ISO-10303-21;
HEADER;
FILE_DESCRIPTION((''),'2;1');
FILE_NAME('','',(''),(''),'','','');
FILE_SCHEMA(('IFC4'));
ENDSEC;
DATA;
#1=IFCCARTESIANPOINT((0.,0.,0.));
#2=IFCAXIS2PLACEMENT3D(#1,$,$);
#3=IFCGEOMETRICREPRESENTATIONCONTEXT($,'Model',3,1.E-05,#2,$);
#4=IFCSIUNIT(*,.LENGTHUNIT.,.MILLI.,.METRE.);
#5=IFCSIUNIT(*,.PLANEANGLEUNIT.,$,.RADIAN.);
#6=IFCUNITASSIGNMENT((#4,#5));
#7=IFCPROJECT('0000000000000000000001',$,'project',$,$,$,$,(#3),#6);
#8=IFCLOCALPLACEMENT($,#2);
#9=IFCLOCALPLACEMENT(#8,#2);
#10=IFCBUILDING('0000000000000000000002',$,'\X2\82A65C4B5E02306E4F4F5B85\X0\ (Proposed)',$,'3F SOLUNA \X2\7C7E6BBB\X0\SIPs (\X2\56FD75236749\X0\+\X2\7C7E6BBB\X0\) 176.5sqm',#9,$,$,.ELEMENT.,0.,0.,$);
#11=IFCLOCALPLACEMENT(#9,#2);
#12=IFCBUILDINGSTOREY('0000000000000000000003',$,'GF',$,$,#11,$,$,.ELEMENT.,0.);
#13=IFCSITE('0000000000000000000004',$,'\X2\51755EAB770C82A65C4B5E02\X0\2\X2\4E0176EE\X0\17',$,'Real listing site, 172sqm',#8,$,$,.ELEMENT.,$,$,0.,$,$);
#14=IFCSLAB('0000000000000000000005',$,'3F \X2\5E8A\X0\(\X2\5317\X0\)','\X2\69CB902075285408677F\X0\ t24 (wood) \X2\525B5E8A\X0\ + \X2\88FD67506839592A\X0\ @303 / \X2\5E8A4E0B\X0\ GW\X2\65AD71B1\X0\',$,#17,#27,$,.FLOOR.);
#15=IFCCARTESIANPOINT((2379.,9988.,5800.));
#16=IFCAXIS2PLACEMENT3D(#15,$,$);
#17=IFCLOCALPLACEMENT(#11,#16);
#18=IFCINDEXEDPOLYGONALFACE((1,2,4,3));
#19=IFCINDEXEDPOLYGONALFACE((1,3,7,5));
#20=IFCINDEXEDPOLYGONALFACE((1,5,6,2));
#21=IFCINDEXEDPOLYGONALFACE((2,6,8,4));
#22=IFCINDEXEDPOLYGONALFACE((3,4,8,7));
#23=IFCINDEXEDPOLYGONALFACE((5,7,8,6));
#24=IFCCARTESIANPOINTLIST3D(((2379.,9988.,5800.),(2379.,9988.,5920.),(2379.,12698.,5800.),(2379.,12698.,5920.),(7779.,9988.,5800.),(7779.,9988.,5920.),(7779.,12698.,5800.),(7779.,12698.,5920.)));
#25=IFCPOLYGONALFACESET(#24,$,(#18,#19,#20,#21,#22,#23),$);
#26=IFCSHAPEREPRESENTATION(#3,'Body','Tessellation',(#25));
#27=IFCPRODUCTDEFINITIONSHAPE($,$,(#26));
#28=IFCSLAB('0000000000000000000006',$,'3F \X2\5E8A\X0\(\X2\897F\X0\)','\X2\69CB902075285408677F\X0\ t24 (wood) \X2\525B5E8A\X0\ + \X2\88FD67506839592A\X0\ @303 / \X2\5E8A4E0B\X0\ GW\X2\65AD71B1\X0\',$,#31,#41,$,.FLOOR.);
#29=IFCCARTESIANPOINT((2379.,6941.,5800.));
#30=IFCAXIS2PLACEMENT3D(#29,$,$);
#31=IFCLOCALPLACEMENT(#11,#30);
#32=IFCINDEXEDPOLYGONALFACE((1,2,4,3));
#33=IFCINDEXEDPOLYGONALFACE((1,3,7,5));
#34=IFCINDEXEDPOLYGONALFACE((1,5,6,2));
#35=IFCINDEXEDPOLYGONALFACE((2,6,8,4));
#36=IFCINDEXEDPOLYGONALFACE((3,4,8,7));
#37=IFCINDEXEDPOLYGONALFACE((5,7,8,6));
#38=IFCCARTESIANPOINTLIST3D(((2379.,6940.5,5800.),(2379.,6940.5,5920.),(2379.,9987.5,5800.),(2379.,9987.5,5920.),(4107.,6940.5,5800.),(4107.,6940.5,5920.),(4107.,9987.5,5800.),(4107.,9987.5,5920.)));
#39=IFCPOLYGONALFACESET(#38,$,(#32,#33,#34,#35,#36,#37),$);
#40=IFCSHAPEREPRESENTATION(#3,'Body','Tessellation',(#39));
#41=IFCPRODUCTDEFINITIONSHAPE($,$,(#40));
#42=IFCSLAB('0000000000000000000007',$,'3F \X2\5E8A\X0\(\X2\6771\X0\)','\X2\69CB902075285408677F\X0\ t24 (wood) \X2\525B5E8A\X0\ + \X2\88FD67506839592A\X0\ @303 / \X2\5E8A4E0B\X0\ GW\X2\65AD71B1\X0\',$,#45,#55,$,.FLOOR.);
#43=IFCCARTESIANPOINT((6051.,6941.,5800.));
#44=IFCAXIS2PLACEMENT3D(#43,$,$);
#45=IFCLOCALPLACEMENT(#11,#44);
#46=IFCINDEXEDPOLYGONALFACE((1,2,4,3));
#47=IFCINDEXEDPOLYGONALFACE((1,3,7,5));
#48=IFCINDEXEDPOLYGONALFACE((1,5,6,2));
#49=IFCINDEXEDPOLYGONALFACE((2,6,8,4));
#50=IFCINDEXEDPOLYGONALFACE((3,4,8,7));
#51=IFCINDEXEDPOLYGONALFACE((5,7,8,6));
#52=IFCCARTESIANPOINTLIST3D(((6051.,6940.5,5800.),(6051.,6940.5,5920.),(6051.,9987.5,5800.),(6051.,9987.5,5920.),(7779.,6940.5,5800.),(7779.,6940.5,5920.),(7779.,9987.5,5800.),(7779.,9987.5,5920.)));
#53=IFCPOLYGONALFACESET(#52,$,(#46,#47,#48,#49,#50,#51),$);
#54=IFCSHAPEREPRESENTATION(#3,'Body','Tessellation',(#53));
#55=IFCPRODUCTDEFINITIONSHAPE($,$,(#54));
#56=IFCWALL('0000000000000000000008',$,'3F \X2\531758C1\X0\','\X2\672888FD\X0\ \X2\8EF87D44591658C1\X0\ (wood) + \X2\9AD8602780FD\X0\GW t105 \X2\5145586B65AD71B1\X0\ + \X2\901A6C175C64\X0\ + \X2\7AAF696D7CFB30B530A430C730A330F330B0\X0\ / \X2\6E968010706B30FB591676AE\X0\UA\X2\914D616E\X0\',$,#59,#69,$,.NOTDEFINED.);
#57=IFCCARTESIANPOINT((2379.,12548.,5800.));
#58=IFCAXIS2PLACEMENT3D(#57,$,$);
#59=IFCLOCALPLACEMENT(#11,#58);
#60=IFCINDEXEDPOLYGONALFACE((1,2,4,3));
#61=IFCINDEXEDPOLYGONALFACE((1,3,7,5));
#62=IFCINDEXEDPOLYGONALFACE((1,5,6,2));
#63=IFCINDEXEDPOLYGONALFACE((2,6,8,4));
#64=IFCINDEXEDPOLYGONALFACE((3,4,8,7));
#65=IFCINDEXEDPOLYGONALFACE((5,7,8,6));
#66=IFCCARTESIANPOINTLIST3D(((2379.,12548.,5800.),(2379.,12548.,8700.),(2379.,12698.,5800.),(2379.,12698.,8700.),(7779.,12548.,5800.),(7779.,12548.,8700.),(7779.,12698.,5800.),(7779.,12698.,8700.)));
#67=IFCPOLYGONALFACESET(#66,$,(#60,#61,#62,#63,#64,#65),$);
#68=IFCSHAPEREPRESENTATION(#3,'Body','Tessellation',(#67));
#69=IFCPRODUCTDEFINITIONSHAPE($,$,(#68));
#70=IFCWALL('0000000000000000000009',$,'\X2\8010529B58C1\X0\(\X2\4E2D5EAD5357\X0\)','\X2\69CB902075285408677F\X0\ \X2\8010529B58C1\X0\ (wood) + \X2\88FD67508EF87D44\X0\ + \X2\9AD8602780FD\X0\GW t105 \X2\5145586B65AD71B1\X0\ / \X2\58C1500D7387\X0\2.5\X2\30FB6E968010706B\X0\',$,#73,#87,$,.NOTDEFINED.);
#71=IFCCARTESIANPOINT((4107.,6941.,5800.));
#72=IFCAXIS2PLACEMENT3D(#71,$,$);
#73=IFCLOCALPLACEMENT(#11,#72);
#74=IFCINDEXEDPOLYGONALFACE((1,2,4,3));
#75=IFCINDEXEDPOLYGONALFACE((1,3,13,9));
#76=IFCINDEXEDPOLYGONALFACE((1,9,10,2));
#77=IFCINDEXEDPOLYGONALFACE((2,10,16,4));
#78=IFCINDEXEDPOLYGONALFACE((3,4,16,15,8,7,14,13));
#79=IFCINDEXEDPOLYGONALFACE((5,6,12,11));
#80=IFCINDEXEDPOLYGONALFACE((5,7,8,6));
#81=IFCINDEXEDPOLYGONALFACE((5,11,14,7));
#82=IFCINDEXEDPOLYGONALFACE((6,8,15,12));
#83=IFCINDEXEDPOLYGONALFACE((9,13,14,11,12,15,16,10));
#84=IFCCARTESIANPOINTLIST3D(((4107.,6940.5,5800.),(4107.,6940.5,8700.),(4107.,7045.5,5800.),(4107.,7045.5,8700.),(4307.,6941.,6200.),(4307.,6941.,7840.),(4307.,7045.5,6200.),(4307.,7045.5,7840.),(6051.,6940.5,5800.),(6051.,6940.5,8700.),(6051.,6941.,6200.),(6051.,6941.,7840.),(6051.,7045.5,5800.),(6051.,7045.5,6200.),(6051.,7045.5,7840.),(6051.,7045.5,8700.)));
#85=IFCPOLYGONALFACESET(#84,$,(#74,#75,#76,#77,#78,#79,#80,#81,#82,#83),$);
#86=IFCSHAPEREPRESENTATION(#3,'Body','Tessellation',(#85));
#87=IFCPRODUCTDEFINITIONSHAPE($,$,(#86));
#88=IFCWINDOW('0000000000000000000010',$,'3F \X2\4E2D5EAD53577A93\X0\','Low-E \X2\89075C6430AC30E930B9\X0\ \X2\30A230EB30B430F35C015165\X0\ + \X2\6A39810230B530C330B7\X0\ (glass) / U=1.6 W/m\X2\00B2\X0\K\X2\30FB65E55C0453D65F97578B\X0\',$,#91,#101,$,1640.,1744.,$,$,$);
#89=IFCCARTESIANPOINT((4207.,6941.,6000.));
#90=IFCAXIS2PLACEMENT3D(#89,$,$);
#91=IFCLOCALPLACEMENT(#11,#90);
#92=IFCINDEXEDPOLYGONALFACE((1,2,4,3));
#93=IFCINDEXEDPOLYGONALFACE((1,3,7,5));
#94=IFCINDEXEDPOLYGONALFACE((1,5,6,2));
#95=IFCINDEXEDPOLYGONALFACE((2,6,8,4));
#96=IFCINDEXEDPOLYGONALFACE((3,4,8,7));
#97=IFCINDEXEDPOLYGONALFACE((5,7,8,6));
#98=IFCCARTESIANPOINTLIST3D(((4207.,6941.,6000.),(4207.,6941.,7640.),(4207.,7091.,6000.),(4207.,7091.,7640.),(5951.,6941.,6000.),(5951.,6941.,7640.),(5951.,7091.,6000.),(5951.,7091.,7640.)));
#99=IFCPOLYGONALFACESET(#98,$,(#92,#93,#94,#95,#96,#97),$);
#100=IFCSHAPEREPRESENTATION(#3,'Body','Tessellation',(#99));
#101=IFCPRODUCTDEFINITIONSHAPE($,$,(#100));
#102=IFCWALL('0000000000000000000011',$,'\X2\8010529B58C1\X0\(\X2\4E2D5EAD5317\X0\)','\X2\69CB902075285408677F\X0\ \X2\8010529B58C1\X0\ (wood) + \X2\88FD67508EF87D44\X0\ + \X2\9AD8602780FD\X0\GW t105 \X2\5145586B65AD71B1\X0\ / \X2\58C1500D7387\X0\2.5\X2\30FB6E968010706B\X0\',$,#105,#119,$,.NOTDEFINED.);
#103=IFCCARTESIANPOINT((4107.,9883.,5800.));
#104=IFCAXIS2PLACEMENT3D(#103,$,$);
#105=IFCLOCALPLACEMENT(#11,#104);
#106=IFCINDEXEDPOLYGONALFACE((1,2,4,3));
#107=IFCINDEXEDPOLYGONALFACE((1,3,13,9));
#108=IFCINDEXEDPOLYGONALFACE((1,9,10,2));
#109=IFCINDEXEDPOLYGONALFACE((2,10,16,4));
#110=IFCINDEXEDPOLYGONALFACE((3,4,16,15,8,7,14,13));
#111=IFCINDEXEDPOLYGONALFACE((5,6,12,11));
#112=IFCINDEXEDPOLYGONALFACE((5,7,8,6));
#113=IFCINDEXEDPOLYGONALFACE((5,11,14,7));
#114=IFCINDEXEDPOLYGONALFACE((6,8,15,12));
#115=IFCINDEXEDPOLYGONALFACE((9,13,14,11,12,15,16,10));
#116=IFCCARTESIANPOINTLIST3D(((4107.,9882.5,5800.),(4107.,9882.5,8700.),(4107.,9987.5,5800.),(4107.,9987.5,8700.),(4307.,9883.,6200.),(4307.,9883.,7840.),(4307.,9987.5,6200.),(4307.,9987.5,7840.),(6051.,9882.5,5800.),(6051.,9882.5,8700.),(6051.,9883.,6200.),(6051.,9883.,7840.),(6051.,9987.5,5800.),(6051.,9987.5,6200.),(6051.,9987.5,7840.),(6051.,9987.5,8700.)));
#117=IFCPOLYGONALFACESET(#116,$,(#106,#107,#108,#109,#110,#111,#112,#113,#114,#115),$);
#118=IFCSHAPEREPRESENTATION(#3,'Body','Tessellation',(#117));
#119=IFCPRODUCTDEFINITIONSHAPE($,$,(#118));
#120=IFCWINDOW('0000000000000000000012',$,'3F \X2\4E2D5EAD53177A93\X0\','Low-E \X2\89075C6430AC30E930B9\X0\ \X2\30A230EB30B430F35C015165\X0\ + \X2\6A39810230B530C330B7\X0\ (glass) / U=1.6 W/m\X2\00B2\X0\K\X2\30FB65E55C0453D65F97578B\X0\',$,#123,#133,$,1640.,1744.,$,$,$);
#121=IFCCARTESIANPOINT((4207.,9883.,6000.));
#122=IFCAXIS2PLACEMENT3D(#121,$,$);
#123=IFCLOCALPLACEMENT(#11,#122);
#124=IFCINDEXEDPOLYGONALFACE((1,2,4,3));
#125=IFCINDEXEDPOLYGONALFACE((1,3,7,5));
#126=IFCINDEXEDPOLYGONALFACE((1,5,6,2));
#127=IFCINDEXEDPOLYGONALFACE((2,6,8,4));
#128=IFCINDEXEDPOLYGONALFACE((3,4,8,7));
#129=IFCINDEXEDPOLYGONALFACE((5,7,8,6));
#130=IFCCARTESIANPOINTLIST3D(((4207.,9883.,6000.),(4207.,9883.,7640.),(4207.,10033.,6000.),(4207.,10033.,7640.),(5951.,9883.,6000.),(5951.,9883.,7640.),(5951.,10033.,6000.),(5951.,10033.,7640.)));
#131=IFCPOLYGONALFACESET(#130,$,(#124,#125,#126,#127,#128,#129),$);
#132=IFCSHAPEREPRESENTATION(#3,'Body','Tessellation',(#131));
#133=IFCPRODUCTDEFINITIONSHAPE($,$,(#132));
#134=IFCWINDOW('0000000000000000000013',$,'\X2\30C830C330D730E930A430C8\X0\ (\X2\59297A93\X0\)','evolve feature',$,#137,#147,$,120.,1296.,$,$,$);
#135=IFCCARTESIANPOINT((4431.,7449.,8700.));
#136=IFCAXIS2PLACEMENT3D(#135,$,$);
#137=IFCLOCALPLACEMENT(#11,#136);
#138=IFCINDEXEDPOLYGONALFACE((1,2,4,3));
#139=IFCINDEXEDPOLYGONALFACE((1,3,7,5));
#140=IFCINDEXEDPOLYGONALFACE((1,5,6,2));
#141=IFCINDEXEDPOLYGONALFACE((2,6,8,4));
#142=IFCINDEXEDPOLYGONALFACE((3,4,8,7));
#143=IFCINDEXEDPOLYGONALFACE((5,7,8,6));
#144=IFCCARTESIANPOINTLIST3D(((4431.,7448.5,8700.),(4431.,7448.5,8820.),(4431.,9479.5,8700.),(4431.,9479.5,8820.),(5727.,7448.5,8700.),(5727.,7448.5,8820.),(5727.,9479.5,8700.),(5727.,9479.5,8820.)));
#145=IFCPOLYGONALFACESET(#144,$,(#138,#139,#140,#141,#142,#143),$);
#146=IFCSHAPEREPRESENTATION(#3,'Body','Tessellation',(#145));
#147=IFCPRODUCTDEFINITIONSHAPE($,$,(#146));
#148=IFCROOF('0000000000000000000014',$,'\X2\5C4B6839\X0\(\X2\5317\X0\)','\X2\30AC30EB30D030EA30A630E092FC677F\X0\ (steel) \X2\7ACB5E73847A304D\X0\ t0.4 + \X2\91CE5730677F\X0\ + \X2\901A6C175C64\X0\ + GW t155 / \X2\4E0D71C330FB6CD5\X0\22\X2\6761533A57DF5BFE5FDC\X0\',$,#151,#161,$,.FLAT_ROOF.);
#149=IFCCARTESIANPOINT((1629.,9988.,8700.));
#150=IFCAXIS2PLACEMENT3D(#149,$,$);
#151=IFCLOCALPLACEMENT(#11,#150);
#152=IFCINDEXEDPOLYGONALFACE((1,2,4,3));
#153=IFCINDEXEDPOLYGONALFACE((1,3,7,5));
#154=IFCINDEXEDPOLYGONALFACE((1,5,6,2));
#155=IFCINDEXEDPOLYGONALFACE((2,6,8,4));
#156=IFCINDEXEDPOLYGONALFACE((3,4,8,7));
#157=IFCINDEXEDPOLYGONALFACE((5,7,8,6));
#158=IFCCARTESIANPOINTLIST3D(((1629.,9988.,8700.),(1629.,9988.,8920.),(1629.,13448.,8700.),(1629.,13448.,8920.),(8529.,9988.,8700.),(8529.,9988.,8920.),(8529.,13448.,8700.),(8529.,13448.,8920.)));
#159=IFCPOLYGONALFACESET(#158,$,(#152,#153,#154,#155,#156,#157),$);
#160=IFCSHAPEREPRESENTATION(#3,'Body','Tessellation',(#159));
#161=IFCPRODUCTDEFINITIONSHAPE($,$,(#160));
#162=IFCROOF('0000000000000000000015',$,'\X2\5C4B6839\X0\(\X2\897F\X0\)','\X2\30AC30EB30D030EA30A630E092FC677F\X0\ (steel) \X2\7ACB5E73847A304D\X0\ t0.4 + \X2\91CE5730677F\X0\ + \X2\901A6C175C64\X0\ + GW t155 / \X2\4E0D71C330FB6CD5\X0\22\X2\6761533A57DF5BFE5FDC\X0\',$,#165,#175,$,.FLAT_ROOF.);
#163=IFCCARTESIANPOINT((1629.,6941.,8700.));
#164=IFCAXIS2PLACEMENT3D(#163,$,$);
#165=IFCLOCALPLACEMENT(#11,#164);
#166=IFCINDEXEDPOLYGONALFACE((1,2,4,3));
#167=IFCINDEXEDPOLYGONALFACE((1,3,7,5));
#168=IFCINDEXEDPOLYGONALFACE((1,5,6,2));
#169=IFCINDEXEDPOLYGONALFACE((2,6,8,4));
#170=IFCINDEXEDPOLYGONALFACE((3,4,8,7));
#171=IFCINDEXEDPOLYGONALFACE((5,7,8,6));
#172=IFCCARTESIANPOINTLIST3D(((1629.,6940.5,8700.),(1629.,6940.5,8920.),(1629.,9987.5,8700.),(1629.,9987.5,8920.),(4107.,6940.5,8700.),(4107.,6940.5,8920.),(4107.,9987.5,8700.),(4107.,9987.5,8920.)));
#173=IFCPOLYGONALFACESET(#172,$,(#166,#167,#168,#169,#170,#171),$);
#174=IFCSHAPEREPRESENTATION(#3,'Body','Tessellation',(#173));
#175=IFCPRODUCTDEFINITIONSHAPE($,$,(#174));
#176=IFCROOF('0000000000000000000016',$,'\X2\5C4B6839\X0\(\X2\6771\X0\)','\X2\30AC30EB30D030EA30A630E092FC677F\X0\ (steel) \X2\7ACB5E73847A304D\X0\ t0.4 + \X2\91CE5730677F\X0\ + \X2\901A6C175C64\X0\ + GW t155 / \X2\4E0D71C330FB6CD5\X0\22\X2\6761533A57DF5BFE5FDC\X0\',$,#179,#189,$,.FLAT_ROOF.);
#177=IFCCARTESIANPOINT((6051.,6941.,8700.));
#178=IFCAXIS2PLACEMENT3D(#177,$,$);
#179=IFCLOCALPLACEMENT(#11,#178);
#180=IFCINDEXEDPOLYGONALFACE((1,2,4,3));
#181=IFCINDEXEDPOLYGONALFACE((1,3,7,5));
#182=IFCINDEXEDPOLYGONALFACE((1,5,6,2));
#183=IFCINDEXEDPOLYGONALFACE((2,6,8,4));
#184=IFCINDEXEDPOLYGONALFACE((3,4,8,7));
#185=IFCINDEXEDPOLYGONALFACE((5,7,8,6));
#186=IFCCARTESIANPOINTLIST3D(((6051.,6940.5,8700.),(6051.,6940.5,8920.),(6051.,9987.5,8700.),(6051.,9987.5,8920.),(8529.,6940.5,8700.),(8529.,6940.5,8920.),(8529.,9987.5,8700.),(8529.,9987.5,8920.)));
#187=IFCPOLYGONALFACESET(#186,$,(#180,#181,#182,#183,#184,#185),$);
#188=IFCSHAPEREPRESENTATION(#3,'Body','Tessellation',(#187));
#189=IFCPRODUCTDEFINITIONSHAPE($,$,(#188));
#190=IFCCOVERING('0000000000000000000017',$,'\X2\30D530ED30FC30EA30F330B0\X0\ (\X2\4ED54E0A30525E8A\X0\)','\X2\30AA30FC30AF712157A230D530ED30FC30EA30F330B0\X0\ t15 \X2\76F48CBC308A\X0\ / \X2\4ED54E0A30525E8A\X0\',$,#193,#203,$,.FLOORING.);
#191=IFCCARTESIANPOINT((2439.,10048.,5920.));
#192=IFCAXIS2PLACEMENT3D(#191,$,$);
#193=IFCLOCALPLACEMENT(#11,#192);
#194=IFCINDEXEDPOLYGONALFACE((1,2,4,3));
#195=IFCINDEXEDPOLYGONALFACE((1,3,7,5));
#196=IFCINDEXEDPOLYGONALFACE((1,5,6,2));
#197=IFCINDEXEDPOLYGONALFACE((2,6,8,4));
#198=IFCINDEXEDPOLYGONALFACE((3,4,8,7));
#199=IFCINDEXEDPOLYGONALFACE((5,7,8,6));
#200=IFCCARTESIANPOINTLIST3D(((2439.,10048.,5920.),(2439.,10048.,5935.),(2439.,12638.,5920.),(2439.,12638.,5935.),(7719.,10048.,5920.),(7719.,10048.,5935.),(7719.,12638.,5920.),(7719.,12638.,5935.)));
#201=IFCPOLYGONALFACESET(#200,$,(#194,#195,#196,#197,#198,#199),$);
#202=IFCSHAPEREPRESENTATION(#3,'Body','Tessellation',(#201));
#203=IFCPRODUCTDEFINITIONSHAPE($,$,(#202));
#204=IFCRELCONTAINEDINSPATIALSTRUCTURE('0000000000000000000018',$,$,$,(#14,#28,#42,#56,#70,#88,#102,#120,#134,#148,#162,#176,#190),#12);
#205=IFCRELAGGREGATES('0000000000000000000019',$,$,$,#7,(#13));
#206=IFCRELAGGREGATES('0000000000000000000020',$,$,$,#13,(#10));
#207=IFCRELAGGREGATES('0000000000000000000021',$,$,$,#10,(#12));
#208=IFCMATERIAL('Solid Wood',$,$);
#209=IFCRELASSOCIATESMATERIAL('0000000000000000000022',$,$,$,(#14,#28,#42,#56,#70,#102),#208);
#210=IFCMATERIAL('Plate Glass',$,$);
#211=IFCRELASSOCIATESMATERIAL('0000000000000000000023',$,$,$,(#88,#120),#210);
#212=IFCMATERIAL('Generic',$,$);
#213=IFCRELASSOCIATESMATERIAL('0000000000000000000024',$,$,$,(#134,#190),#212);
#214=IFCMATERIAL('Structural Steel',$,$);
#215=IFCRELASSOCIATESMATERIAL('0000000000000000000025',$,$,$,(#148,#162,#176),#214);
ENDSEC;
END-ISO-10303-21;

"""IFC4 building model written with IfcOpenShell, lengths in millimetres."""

from ifc_helpers import new_model, si_unit, frame, frame_2d, origin, place, context, project, spatial, rectangle, extrude, material, element, fill, save


model = new_model("IFC4")

# Units and contexts
model_context = context("Model", 3, precision=1e-05, world=origin())
ifc_project = project(units=[si_unit("LENGTHUNIT", "METRE", prefix="MILLI"), si_unit("PLANEANGLEUNIT", "RADIAN")], contexts=[model_context])

# Site, building, storey
site_placement = place(None, origin())
site = spatial("IfcSite", under=ifc_project, at=site_placement, Name="兵庫県芦屋市2丁目17", ObjectType="Real listing site, 172sqm", CompositionType="ELEMENT", RefElevation=0.0)
building_placement = place(site_placement, origin())
building = spatial("IfcBuilding", under=site, at=building_placement, Name="芦屋市の住宅 (Proposed)", ObjectType="3F SOLUNA 籾殻SIPs (国産杉+籾殻) 176.5sqm", CompositionType="ELEMENT", ElevationOfRefHeight=0.0, ElevationOfTerrain=0.0)
storey_placement = place(building_placement, origin())
storey = spatial("IfcBuildingStorey", under=building, at=storey_placement, Name="GF", CompositionType="ELEMENT", Elevation=0.0)

# Slabs
ifc_material_1 = material(Name="Solid Wood")
slab_1_placement = place(storey_placement, frame((2379.0, 9988.0, 5800.0)))
element("IfcSlab", 1, at=slab_1_placement, inside=storey, material=ifc_material_1, Name="3F 床(北)", Description="構造用合板 t24 (wood) 剛床 + 製材根太 @303 / 床下 GW断熱", PredefinedType="FLOOR", context=model_context, shape_type="SweptSolid", body=[
    extrude(rectangle(XDim=5400.0, YDim=2710.0, at=frame_2d((2700.0, 1355.0))), frame((2379.0, 9988.0, 5800.0)), (0.0, 0.0, 1.0), 120.0),
])
slab_2_placement = place(storey_placement, frame((2379.0, 6941.0, 5800.0)))
element("IfcSlab", 2, at=slab_2_placement, inside=storey, material=ifc_material_1, Name="3F 床(西)", Description="構造用合板 t24 (wood) 剛床 + 製材根太 @303 / 床下 GW断熱", PredefinedType="FLOOR", context=model_context, shape_type="SweptSolid", body=[
    extrude(rectangle(XDim=1728.0, YDim=3047.0, at=frame_2d((864.0, 1523.0))), frame((2379.0, 6941.0, 5800.0)), (0.0, 0.0, 1.0), 120.0),
])
slab_3_placement = place(storey_placement, frame((6051.0, 6941.0, 5800.0)))
element("IfcSlab", 3, at=slab_3_placement, inside=storey, material=ifc_material_1, Name="3F 床(東)", Description="構造用合板 t24 (wood) 剛床 + 製材根太 @303 / 床下 GW断熱", PredefinedType="FLOOR", context=model_context, shape_type="SweptSolid", body=[
    extrude(rectangle(XDim=1728.0, YDim=3047.0, at=frame_2d((864.0, 1523.0))), frame((6051.0, 6941.0, 5800.0)), (0.0, 0.0, 1.0), 120.0),
])

# Wall
wall_1_placement = place(storey_placement, frame((2379.0, 12548.0, 5800.0)))
element("IfcWall", 4, at=wall_1_placement, inside=storey, material=ifc_material_1, Name="3F 北壁", Description="木製 軸組外壁 (wood) + 高性能GW t105 充填断熱 + 通気層 + 窯業系サイディング / 準耐火・外皮UA配慮", PredefinedType="NOTDEFINED", context=model_context, shape_type="SweptSolid", body=[
    extrude(rectangle(XDim=5400.0, YDim=150.0, at=frame_2d((2700.0, 75.0))), frame((2379.0, 12548.0, 5800.0)), (0.0, 0.0, 1.0), 2900.0),
])

# Walls, openings, windows
wall_2_placement = place(storey_placement, frame((4107.0, 6941.0, 5800.0)))
wall_2 = element("IfcWall", 5, at=wall_2_placement, inside=storey, material=ifc_material_1, Name="耐力壁(中庭南)", Description="構造用合板 耐力壁 (wood) + 製材軸組 + 高性能GW t105 充填断熱 / 壁倍率2.5・準耐火", PredefinedType="NOTDEFINED", context=model_context, shape_type="SweptSolid", body=[
    extrude(rectangle(XDim=1944.0, YDim=105.0, at=frame_2d((972.0, 52.0))), frame((4107.0, 6941.0, 5800.0)), (0.0, 0.0, 1.0), 2900.0),
])
opening_1_placement = place(storey_placement, frame((4207.0, 6941.0, 6000.0)))
opening_1 = element("IfcOpeningElement", 6, at=opening_1_placement, cuts=wall_2, PredefinedType="NOTDEFINED", context=model_context, shape_type="SweptSolid", body=[
    extrude(rectangle(XDim=1744.0, YDim=150.0, at=frame_2d((872.0, 75.0))), frame((4207.0, 6941.0, 6000.0)), (0.0, 0.0, 1.0), 1640.0),
])
ifc_material_2 = material(Name="Plate Glass")
window_1_placement = place(storey_placement, frame((4207.0, 6941.0, 6000.0)))
window_1 = element("IfcWindow", 7, at=window_1_placement, inside=storey, material=ifc_material_2, Name="3F 中庭南窓", Description="Low-E 複層ガラス アルゴン封入 + 樹脂サッシ (glass) / U=1.6 W/m²K・日射取得型", OverallHeight=1640.0, OverallWidth=1744.0, context=model_context, shape_type="SweptSolid", body=[
    extrude(rectangle(XDim=1744.0, YDim=150.0, at=frame_2d((872.0, 75.0))), frame((4207.0, 6941.0, 6000.0)), (0.0, 0.0, 1.0), 1640.0),
])
fill(opening_1, window_1)
wall_3_placement = place(storey_placement, frame((4107.0, 9883.0, 5800.0)))
wall_3 = element("IfcWall", 8, at=wall_3_placement, inside=storey, material=ifc_material_1, Name="耐力壁(中庭北)", Description="構造用合板 耐力壁 (wood) + 製材軸組 + 高性能GW t105 充填断熱 / 壁倍率2.5・準耐火", PredefinedType="NOTDEFINED", context=model_context, shape_type="SweptSolid", body=[
    extrude(rectangle(XDim=1944.0, YDim=105.0, at=frame_2d((972.0, 52.0))), frame((4107.0, 9883.0, 5800.0)), (0.0, 0.0, 1.0), 2900.0),
])
opening_2_placement = place(storey_placement, frame((4207.0, 9883.0, 6000.0)))
opening_2 = element("IfcOpeningElement", 9, at=opening_2_placement, cuts=wall_3, PredefinedType="NOTDEFINED", context=model_context, shape_type="SweptSolid", body=[
    extrude(rectangle(XDim=1744.0, YDim=150.0, at=frame_2d((872.0, 75.0))), frame((4207.0, 9883.0, 6000.0)), (0.0, 0.0, 1.0), 1640.0),
])
window_2_placement = place(storey_placement, frame((4207.0, 9883.0, 6000.0)))
window_2 = element("IfcWindow", 10, at=window_2_placement, inside=storey, material=ifc_material_2, Name="3F 中庭北窓", Description="Low-E 複層ガラス アルゴン封入 + 樹脂サッシ (glass) / U=1.6 W/m²K・日射取得型", OverallHeight=1640.0, OverallWidth=1744.0, context=model_context, shape_type="SweptSolid", body=[
    extrude(rectangle(XDim=1744.0, YDim=150.0, at=frame_2d((872.0, 75.0))), frame((4207.0, 9883.0, 6000.0)), (0.0, 0.0, 1.0), 1640.0),
])
fill(opening_2, window_2)

# Window
ifc_material_3 = material(Name="Generic")
window_3_placement = place(storey_placement, frame((4431.0, 7449.0, 8700.0)))
element("IfcWindow", 11, at=window_3_placement, inside=storey, material=ifc_material_3, Name="トップライト (天窓)", Description="evolve feature", OverallHeight=120.0, OverallWidth=1296.0, context=model_context, shape_type="SweptSolid", body=[
    extrude(rectangle(XDim=1296.0, YDim=2031.0, at=frame_2d((648.0, 1015.0))), frame((4431.0, 7449.0, 8700.0)), (0.0, 0.0, 1.0), 120.0),
])

# Roofs
ifc_material_4 = material(Name="Structural Steel")
for number, where, name in (
    (12, (1629.0, 9988.0, 8700.0), "屋根(北)"),
):
    element("IfcRoof", number, at=place(storey_placement, frame(where)), inside=storey, material=ifc_material_4, Name=name, Description="ガルバリウム鋼板 (steel) 立平葺き t0.4 + 野地板 + 通気層 + GW t155 / 不燃・法22条区域対応", PredefinedType="FLAT_ROOF", context=model_context, shape_type="SweptSolid", body=[
        extrude(rectangle(XDim=6900.0, YDim=3460.0, at=frame_2d((3450.0, 1730.0))), frame((1629.0, 9988.0, 8700.0)), (0.0, 0.0, 1.0), 220.0),
    ])
roof_1_placement = place(storey_placement, frame((1629.0, 6941.0, 8700.0)))
element("IfcRoof", 13, at=roof_1_placement, inside=storey, material=ifc_material_4, Name="屋根(西)", Description="ガルバリウム鋼板 (steel) 立平葺き t0.4 + 野地板 + 通気層 + GW t155 / 不燃・法22条区域対応", PredefinedType="FLAT_ROOF", context=model_context, shape_type="SweptSolid", body=[
    extrude(rectangle(XDim=2478.0, YDim=3047.0, at=frame_2d((1239.0, 1523.0))), frame((1629.0, 6941.0, 8700.0)), (0.0, 0.0, 1.0), 220.0),
])
roof_2_placement = place(storey_placement, frame((6051.0, 6941.0, 8700.0)))
element("IfcRoof", 14, at=roof_2_placement, inside=storey, material=ifc_material_4, Name="屋根(東)", Description="ガルバリウム鋼板 (steel) 立平葺き t0.4 + 野地板 + 通気層 + GW t155 / 不燃・法22条区域対応", PredefinedType="FLAT_ROOF", context=model_context, shape_type="SweptSolid", body=[
    extrude(rectangle(XDim=2478.0, YDim=3047.0, at=frame_2d((1239.0, 1523.0))), frame((6051.0, 6941.0, 8700.0)), (0.0, 0.0, 1.0), 220.0),
])

# Covering
covering_1_placement = place(storey_placement, frame((2439.0, 10048.0, 5920.0)))
element("IfcCovering", 15, at=covering_1_placement, inside=storey, material=ifc_material_3, Name="フローリング (仕上げ床)", Description="オーク無垢フローリング t15 直貼り / 仕上げ床", PredefinedType="FLOORING", context=model_context, shape_type="SweptSolid", body=[
    extrude(rectangle(XDim=5280.0, YDim=2590.0, at=frame_2d((2640.0, 1295.0))), frame((2439.0, 10048.0, 5920.0)), (0.0, 0.0, 1.0), 15.0),
])

save(model, "model.ifc")
